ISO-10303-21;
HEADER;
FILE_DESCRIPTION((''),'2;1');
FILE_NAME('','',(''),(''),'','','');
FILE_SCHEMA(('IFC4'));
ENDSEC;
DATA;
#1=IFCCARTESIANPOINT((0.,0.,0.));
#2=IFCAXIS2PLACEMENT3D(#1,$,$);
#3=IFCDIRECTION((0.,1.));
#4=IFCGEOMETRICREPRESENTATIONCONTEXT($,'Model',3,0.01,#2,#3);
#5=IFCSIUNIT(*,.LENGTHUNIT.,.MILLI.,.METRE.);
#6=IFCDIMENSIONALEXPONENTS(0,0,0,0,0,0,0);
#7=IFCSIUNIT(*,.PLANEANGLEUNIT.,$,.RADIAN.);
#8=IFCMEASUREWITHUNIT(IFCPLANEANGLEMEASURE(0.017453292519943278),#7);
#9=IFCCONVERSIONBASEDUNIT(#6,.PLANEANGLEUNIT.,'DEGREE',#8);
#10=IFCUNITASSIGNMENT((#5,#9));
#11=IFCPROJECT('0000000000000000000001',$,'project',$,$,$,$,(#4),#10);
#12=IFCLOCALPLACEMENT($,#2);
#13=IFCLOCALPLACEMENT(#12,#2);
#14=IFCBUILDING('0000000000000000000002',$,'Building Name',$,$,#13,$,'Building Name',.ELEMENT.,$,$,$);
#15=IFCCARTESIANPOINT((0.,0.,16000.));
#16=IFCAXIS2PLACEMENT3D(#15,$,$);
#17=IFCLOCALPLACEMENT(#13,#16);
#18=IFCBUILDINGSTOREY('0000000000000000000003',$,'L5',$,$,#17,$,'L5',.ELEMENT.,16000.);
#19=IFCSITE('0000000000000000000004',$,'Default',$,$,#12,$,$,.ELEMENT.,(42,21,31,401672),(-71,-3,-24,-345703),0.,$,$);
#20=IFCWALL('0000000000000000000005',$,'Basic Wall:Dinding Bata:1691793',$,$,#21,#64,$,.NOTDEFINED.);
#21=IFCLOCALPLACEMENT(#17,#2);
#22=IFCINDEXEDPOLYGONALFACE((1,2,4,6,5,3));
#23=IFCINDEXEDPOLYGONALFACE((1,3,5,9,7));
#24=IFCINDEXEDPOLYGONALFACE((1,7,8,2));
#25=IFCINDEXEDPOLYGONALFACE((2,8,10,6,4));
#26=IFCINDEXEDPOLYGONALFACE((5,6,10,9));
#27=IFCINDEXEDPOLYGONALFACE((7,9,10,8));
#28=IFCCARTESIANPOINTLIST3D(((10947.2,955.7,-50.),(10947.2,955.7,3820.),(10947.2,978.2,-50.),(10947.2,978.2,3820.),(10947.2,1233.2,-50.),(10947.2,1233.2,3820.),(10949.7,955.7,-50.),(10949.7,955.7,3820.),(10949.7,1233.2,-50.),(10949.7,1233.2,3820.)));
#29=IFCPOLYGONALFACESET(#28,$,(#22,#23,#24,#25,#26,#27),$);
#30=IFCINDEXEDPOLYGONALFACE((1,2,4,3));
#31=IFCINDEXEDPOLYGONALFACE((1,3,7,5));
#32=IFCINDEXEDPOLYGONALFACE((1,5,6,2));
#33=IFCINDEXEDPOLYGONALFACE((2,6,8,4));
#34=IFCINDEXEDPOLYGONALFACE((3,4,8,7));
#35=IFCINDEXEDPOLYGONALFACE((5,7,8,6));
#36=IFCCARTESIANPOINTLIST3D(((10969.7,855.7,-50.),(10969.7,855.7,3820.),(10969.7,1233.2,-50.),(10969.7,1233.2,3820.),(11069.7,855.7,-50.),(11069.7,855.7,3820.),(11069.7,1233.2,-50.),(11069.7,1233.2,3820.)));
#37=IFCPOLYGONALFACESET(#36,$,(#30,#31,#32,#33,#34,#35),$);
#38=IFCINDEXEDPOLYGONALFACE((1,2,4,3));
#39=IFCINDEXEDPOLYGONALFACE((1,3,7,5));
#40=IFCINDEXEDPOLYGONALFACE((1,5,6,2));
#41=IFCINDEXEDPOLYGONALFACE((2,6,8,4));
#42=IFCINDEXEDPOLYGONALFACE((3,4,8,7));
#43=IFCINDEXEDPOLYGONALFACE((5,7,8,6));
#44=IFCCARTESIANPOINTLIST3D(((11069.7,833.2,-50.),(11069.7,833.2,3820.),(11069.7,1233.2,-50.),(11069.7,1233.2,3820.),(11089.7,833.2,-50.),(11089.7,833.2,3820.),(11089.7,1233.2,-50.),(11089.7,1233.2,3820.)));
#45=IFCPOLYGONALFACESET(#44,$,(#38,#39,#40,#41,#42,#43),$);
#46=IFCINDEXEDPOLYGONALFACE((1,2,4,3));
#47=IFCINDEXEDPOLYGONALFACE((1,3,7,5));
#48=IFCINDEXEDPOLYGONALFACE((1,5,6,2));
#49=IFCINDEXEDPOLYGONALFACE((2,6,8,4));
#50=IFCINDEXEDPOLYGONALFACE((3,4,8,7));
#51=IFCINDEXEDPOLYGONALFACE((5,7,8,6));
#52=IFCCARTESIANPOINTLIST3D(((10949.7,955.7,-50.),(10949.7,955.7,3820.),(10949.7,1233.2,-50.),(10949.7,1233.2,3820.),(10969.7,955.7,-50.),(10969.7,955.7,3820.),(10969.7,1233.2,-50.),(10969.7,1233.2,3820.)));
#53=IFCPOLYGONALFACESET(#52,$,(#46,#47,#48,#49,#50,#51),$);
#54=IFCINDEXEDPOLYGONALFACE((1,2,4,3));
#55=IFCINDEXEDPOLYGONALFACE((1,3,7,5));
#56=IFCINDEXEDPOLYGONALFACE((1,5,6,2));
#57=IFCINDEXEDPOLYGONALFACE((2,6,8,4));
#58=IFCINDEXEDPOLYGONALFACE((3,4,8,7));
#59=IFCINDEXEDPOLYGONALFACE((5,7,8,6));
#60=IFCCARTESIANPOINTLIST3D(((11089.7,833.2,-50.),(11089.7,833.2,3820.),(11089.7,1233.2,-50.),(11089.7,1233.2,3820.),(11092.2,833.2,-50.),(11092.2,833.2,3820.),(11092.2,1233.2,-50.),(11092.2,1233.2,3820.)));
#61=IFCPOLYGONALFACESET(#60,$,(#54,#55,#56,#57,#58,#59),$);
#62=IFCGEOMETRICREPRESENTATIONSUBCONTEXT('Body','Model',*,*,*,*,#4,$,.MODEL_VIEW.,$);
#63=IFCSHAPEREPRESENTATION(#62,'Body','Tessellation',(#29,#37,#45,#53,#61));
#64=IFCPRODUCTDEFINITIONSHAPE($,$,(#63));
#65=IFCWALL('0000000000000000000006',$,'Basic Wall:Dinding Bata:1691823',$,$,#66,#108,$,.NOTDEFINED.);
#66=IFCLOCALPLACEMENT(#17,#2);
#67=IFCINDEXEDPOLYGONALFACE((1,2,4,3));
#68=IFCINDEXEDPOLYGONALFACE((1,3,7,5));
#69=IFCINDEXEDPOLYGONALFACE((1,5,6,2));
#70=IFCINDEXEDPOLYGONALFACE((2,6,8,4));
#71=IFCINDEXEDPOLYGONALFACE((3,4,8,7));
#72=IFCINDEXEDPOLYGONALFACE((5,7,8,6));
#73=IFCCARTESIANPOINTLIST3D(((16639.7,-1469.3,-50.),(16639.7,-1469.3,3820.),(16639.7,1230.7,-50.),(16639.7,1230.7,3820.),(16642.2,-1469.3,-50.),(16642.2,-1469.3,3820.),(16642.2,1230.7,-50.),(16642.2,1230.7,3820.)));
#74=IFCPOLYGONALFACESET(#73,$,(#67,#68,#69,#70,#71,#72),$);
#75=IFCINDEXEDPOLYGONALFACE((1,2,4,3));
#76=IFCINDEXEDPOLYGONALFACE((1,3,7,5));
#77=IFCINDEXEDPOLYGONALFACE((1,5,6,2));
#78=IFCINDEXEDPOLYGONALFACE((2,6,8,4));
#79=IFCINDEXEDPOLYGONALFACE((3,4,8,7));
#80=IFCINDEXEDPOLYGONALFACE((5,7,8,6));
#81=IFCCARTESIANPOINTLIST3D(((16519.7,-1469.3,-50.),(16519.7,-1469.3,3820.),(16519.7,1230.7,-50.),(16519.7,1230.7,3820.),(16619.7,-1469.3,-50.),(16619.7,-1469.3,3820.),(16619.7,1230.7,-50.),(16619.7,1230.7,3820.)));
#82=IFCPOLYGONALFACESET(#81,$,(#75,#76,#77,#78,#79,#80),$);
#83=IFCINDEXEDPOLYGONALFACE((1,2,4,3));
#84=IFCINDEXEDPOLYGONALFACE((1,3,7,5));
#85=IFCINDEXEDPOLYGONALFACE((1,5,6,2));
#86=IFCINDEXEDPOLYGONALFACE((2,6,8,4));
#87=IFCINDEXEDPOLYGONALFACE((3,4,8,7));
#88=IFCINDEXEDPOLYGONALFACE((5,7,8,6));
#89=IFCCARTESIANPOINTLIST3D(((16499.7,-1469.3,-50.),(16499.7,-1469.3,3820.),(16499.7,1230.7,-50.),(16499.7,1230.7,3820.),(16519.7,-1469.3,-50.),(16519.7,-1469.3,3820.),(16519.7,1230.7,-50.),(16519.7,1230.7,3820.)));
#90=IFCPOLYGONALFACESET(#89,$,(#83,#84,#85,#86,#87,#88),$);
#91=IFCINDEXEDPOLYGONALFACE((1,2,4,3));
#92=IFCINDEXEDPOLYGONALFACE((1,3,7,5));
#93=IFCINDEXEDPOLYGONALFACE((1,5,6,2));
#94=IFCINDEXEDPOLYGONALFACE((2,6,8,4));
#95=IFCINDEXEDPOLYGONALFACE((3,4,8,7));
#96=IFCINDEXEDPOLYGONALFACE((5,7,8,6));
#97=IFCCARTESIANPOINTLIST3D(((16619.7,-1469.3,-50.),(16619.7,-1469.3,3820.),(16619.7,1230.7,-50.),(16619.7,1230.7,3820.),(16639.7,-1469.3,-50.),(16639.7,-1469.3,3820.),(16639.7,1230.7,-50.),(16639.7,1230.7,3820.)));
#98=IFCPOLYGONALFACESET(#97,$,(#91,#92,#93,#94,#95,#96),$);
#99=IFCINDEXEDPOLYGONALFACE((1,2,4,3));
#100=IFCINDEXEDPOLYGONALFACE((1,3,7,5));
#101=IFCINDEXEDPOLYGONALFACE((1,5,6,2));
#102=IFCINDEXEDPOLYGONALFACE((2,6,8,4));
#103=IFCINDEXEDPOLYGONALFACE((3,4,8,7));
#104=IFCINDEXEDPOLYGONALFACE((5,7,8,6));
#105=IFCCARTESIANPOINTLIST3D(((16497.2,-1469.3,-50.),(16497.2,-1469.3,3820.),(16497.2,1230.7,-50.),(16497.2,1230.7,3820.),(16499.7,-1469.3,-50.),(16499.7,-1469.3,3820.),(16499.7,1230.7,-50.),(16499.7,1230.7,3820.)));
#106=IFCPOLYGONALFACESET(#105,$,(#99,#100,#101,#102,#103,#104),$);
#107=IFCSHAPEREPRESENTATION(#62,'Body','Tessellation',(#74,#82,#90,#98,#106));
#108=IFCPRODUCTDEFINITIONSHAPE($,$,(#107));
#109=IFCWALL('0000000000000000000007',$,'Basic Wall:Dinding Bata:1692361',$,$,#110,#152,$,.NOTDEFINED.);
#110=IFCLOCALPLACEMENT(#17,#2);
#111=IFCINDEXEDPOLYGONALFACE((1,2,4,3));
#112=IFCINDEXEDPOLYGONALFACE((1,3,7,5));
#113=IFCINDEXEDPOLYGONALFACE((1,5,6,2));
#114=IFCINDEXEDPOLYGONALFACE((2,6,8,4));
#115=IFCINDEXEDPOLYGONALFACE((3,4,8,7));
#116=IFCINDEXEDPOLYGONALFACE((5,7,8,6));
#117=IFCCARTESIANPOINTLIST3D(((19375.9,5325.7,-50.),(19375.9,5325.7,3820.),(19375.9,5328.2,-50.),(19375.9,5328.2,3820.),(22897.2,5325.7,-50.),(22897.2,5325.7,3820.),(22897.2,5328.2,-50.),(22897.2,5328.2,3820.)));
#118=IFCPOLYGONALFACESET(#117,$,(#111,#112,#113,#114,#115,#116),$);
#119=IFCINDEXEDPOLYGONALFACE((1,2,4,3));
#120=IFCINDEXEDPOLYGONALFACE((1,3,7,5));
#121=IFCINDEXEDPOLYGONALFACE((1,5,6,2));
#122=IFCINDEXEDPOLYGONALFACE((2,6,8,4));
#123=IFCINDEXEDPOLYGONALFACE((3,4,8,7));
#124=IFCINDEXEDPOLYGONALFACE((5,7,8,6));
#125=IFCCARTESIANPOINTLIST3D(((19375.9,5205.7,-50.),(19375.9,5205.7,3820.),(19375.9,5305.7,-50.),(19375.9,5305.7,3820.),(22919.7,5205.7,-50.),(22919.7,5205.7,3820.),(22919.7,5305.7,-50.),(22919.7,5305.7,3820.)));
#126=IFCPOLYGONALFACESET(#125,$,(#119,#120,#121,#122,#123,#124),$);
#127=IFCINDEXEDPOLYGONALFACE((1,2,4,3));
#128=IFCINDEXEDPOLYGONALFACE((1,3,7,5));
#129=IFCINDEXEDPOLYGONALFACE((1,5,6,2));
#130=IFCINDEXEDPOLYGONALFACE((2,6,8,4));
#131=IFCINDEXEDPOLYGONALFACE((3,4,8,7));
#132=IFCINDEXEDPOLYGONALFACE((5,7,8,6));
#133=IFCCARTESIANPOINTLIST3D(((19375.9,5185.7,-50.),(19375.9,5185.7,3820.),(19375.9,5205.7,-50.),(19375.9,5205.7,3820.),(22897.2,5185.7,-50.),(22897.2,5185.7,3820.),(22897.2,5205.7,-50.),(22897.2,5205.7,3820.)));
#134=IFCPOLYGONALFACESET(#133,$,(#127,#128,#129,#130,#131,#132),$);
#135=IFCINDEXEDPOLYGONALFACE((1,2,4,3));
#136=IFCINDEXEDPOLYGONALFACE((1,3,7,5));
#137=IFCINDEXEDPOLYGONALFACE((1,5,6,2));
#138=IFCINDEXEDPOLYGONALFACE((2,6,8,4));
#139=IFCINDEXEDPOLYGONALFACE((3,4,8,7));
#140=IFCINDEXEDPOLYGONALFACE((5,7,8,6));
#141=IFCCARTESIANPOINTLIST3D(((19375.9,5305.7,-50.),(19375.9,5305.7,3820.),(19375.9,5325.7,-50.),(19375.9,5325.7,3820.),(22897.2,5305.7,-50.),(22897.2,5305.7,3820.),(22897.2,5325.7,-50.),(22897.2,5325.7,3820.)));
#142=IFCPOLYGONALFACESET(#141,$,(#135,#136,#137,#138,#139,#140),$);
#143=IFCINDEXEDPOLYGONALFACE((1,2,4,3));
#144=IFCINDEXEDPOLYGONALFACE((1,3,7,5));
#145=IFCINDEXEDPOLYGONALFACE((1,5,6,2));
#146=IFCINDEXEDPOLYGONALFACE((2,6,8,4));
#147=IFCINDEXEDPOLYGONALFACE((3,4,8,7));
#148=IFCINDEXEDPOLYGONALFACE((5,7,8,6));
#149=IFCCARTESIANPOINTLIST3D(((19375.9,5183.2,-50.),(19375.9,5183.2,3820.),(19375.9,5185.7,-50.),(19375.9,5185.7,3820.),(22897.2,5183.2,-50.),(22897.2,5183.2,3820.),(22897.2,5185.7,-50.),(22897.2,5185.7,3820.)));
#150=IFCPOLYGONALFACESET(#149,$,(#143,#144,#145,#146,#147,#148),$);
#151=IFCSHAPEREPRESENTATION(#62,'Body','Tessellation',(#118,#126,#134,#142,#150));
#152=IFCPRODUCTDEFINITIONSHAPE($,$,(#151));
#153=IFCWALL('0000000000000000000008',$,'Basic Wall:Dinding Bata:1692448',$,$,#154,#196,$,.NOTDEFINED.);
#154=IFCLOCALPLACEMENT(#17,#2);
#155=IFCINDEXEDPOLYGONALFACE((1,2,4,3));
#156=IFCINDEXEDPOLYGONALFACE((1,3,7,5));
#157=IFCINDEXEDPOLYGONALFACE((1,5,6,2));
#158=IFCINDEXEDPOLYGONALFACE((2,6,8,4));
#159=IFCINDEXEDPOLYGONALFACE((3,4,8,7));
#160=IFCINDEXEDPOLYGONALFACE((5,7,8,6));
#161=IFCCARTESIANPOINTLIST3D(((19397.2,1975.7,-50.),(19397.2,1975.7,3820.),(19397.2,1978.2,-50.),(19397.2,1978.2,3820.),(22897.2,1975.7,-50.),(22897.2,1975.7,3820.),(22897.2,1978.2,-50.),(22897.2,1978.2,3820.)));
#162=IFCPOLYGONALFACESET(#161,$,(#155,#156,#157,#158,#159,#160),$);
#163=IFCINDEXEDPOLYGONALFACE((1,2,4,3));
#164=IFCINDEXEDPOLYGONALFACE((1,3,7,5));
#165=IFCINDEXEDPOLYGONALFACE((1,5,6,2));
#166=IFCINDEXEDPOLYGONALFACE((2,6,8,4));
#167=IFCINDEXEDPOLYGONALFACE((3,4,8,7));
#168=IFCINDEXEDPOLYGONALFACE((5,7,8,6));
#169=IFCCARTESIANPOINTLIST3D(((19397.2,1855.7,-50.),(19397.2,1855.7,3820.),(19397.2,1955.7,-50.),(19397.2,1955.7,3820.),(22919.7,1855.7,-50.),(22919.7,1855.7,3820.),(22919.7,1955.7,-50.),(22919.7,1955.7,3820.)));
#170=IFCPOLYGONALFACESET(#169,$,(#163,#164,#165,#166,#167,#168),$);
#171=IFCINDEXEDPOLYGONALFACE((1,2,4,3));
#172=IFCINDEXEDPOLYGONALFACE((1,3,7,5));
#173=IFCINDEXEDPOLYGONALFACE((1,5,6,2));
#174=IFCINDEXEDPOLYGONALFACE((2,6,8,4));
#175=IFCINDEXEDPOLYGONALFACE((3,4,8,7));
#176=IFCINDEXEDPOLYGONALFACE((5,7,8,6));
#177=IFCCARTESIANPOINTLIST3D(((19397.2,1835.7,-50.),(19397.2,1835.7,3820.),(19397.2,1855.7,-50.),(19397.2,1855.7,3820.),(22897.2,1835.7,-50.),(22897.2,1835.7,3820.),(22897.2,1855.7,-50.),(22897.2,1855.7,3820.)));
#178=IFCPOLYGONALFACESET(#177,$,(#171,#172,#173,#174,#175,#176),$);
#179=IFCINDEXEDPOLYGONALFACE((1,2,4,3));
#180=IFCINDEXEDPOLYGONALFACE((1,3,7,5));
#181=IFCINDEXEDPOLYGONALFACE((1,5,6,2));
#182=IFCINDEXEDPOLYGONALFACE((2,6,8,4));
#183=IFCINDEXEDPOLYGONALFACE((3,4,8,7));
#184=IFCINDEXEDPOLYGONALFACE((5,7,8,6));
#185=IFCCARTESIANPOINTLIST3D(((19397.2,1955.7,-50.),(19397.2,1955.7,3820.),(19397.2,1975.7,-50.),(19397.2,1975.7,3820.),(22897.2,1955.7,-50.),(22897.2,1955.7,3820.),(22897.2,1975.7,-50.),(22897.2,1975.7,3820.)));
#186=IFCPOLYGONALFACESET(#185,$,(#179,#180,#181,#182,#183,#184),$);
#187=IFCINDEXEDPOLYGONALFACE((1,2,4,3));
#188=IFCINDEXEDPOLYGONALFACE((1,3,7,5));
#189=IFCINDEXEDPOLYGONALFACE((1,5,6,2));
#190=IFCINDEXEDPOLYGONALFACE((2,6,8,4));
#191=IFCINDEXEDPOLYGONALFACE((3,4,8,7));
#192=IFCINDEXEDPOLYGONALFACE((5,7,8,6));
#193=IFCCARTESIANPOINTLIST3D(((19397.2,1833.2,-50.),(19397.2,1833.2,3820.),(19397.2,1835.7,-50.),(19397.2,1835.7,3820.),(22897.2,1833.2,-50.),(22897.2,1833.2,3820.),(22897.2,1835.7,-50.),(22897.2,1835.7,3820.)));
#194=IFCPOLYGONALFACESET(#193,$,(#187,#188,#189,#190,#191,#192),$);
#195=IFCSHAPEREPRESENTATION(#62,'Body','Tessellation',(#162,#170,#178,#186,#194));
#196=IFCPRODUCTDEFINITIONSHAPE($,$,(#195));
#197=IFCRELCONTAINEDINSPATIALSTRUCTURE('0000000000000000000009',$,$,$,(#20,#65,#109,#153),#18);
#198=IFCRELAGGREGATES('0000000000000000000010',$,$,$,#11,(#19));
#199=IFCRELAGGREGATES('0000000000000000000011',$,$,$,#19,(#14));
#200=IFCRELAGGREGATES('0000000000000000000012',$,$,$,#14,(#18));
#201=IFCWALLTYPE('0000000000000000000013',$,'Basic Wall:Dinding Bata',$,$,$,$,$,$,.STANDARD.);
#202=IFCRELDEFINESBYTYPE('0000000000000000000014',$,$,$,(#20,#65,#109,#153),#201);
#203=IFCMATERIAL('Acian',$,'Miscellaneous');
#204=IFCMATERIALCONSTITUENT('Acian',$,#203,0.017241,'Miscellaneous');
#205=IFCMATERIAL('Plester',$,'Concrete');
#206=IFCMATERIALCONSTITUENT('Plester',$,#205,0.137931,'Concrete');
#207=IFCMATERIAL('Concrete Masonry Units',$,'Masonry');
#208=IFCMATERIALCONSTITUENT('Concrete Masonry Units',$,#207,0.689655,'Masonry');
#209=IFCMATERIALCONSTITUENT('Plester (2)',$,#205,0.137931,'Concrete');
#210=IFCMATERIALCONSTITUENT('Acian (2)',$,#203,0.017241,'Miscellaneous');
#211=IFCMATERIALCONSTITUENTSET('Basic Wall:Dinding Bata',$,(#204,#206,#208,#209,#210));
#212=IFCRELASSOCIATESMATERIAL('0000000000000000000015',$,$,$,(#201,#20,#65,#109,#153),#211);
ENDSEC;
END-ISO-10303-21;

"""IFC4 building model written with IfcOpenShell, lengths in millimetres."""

from ifc_helpers import new_model, entity, si_unit, converted_unit, direction, frame, origin, place, context, subcontext, project, spatial, indexed_curve, outline, extrude, material, constituent, constituent_set, type_object, element, save


model = new_model("IFC4")

# Units and contexts
model_context = context("Model", 3, precision=0.01, world=origin(), true_north=direction((0.0, 1.0)))
body_context = subcontext(model_context, "Body", "Model", "MODEL_VIEW")
ifc_project = project(units=[si_unit("LENGTHUNIT", "METRE", prefix="MILLI"), converted_unit("PLANEANGLEUNIT", "DEGREE", entity("IfcPlaneAngleMeasure", 0.017453292519943278), si_unit("PLANEANGLEUNIT", "RADIAN"), dimensions=[0, 0, 0, 0, 0, 0, 0])], contexts=[model_context])

# Site, building, storey
site_placement = place(None, origin())
site = spatial("IfcSite", under=ifc_project, at=site_placement, Name="Default", CompositionType="ELEMENT", RefLatitude=(42, 21, 31, 401672), RefLongitude=(-71, -3, -24, -345703), RefElevation=0.0)
building_placement = place(site_placement, origin())
building = spatial("IfcBuilding", under=site, at=building_placement, Name="Building Name", LongName="Building Name", CompositionType="ELEMENT")
storey_placement = place(building_placement, frame((0.0, 0.0, 16000.0)))
storey = spatial("IfcBuildingStorey", under=building, at=storey_placement, Name="L5", LongName="L5", CompositionType="ELEMENT", Elevation=16000.0)

# Walls
ifc_material_1 = material(Name="Acian", Category="Miscellaneous")
ifc_constituent_1 = constituent(ifc_material_1, Name="Acian", Category="Miscellaneous", fraction=0.017241)
ifc_material_2 = material(Name="Plester", Category="Concrete")
ifc_constituent_2 = constituent(ifc_material_2, Name="Plester", Category="Concrete", fraction=0.137931)
ifc_material_3 = material(Name="Concrete Masonry Units", Category="Masonry")
ifc_constituent_3 = constituent(ifc_material_3, Name="Concrete Masonry Units", Category="Masonry", fraction=0.689655)
ifc_constituent_4 = constituent(ifc_material_2, Name="Plester (2)", Category="Concrete", fraction=0.137931)
ifc_constituent_5 = constituent(ifc_material_1, Name="Acian (2)", Category="Miscellaneous", fraction=0.017241)
ifc_constituent_set = constituent_set(constituents=[ifc_constituent_1, ifc_constituent_2, ifc_constituent_3, ifc_constituent_4, ifc_constituent_5], Name="Basic Wall:Dinding Bata")
wall_type = type_object("IfcWallType", Name="Basic Wall:Dinding Bata", PredefinedType="STANDARD", material=ifc_constituent_set)
wall_1_placement = place(storey_placement, frame((11019.7, 833.2, -50.0), z_axis=(0.0, 0.0, 1.0), x_axis=(0.0, 1.0, 0.0)))
element("IfcWall", 1, at=wall_1_placement, inside=storey, type_object=wall_type, material=ifc_constituent_set, Name="Basic Wall:Dinding Bata:1691793", PredefinedType="NOTDEFINED", context=body_context, shape_type="SweptSolid", body=[
    extrude(outline(indexed_curve([(93.0, -1.0), (115.5, -1.0), (115.5, 1.5), (-162.0, 1.5), (-162.0, -1.0), (93.0, -1.0)], self_intersect=False)), frame((238.0, 71.5, 0.0), z_axis=(0.0, 0.0, 1.0), x_axis=(-1.0, 0.0, 0.0)), (0.0, 0.0, 1.0), 3870.0),
    extrude(outline(indexed_curve([(-188.7, -50.0), (188.7, -50.0), (188.8, 50.0), (-188.7, 50.0), (-188.7, -50.0)], self_intersect=False)), frame((211.3, 0.0, 0.0)), (0.0, 0.0, 1.0), 3870.0),
    extrude(outline(indexed_curve([(-200.0, -10.0), (200.0, -10.0), (200.0, 10.0), (-200.0, 10.0), (-200.0, -10.0)], self_intersect=False)), frame((200.0, -60.0, 0.0)), (0.0, 0.0, 1.0), 3870.0),
    extrude(outline(indexed_curve([(-138.7, -10.0), (138.7, -10.0), (138.7, 10.0), (-138.7, 10.0), (-138.7, -10.0)], self_intersect=False)), frame((261.3, 60.0, 0.0)), (0.0, 0.0, 1.0), 3870.0),
    extrude(outline(indexed_curve([(-1.3, -200.0), (1.2, -200.0), (1.2, 200.0), (-1.2, 200.0), (-1.3, -200.0)], self_intersect=False)), frame((200.0, -71.2, 0.0), z_axis=(0.0, 0.0, 1.0), x_axis=(0.0, 1.0, 0.0)), (0.0, 0.0, 1.0), 3870.0),
])
wall_2_placement = place(storey_placement, frame((16569.7, 1230.7, -50.0), z_axis=(0.0, 0.0, 1.0), x_axis=(0.0, -1.0, 0.0)))
element("IfcWall", 2, at=wall_2_placement, inside=storey, type_object=wall_type, material=ifc_constituent_set, Name="Basic Wall:Dinding Bata:1691823", PredefinedType="NOTDEFINED", context=body_context, shape_type="SweptSolid", body=[
    extrude(outline(indexed_curve([(-1.3, -1350.0), (1.2, -1350.0), (1.3, 1350.0), (-1.2, 1350.0), (-1.3, -1350.0)], self_intersect=False)), frame((1350.0, 71.2, 0.0), z_axis=(0.0, 0.0, 1.0), x_axis=(0.0, -1.0, 0.0)), (0.0, 0.0, 1.0), 3870.0),
    extrude(outline(indexed_curve([(-1350.0, -50.0), (1350.0, -50.0), (1350.0, 50.0), (-1350.0, 50.0), (-1350.0, -50.0)], self_intersect=False)), frame((1350.0, 0.0, 0.0)), (0.0, 0.0, 1.0), 3870.0),
    extrude(outline(indexed_curve([(-1350.0, -10.0), (1350.0, -10.0), (1350.0, 10.0), (-1350.0, 10.0), (-1350.0, -10.0)], self_intersect=False)), frame((1350.0, -60.0, 0.0)), (0.0, 0.0, 1.0), 3870.0),
    extrude(outline(indexed_curve([(-1350.0, -10.0), (1350.0, -10.0), (1350.0, 10.0), (-1350.0, 10.0), (-1350.0, -10.0)], self_intersect=False)), frame((1350.0, 60.0, 0.0)), (0.0, 0.0, 1.0), 3870.0),
    extrude(outline(indexed_curve([(-1.3, -1350.0), (1.2, -1350.0), (1.3, 1350.0), (-1.2, 1350.0), (-1.3, -1350.0)], self_intersect=False)), frame((1350.0, -71.2, 0.0), z_axis=(0.0, 0.0, 1.0), x_axis=(0.0, 1.0, 0.0)), (0.0, 0.0, 1.0), 3870.0),
])
wall_3_placement = place(storey_placement, frame((19375.9, 5255.7, -50.0)))
element("IfcWall", 3, at=wall_3_placement, inside=storey, type_object=wall_type, material=ifc_constituent_set, Name="Basic Wall:Dinding Bata:1692361", PredefinedType="NOTDEFINED", context=body_context, shape_type="SweptSolid", body=[
    extrude(outline(indexed_curve([(-1.3, -1760.7), (1.2, -1760.7), (1.3, 1760.7), (-1.2, 1760.7), (-1.3, -1760.7)], self_intersect=False)), frame((1760.7, 71.3, 0.0), z_axis=(0.0, 0.0, 1.0), x_axis=(0.0, -1.0, 0.0)), (0.0, 0.0, 1.0), 3870.0),
    extrude(outline(indexed_curve([(-1771.9, -50.0), (1771.9, -50.0), (1771.9, 50.0), (-1771.9, 50.0), (-1771.9, -50.0)], self_intersect=False)), frame((1771.9, 0.0, 0.0)), (0.0, 0.0, 1.0), 3870.0),
    extrude(outline(indexed_curve([(-1760.7, -10.0), (1760.7, -10.0), (1760.7, 10.0), (-1760.7, 10.0), (-1760.7, -10.0)], self_intersect=False)), frame((1760.7, -60.0, 0.0)), (0.0, 0.0, 1.0), 3870.0),
    extrude(outline(indexed_curve([(-1760.7, -10.0), (1760.7, -10.0), (1760.7, 10.0), (-1760.7, 10.0), (-1760.7, -10.0)], self_intersect=False)), frame((1760.7, 60.0, 0.0)), (0.0, 0.0, 1.0), 3870.0),
    extrude(outline(indexed_curve([(-1.3, -1760.7), (1.2, -1760.7), (1.3, 1760.7), (-1.2, 1760.7), (-1.3, -1760.7)], self_intersect=False)), frame((1760.7, -71.2, 0.0), z_axis=(0.0, 0.0, 1.0), x_axis=(0.0, 1.0, 0.0)), (0.0, 0.0, 1.0), 3870.0),
])
wall_4_placement = place(storey_placement, frame((19397.2, 1905.7, -50.0)))
element("IfcWall", 4, at=wall_4_placement, inside=storey, type_object=wall_type, material=ifc_constituent_set, Name="Basic Wall:Dinding Bata:1692448", PredefinedType="NOTDEFINED", context=body_context, shape_type="SweptSolid", body=[
    extrude(outline(indexed_curve([(-1.3, -1750.0), (1.2, -1750.0), (1.3, 1750.0), (-1.2, 1750.0), (-1.3, -1750.0)], self_intersect=False)), frame((1750.0, 71.3, 0.0), z_axis=(0.0, 0.0, 1.0), x_axis=(0.0, -1.0, 0.0)), (0.0, 0.0, 1.0), 3870.0),
    extrude(outline(indexed_curve([(-1761.2, -50.0), (1761.3, -50.0), (1761.3, 50.0), (-1761.2, 50.0), (-1761.2, -50.0)], self_intersect=False)), frame((1761.2, 0.0, 0.0)), (0.0, 0.0, 1.0), 3870.0),
    extrude(outline(indexed_curve([(-1750.0, -10.0), (1750.0, -10.0), (1750.0, 10.0), (-1750.0, 10.0), (-1750.0, -10.0)], self_intersect=False)), frame((1750.0, -60.0, 0.0)), (0.0, 0.0, 1.0), 3870.0),
    extrude(outline(indexed_curve([(-1750.0, -10.0), (1750.0, -10.0), (1750.0, 10.0), (-1750.0, 10.0), (-1750.0, -10.0)], self_intersect=False)), frame((1750.0, 60.0, 0.0)), (0.0, 0.0, 1.0), 3870.0),
    extrude(outline(indexed_curve([(-1.3, -1750.0), (1.2, -1750.0), (1.3, 1750.0), (-1.2, 1750.0), (-1.3, -1750.0)], self_intersect=False)), frame((1750.0, -71.2, 0.0), z_axis=(0.0, 0.0, 1.0), x_axis=(0.0, 1.0, 0.0)), (0.0, 0.0, 1.0), 3870.0),
])

save(model, "model.ifc")
